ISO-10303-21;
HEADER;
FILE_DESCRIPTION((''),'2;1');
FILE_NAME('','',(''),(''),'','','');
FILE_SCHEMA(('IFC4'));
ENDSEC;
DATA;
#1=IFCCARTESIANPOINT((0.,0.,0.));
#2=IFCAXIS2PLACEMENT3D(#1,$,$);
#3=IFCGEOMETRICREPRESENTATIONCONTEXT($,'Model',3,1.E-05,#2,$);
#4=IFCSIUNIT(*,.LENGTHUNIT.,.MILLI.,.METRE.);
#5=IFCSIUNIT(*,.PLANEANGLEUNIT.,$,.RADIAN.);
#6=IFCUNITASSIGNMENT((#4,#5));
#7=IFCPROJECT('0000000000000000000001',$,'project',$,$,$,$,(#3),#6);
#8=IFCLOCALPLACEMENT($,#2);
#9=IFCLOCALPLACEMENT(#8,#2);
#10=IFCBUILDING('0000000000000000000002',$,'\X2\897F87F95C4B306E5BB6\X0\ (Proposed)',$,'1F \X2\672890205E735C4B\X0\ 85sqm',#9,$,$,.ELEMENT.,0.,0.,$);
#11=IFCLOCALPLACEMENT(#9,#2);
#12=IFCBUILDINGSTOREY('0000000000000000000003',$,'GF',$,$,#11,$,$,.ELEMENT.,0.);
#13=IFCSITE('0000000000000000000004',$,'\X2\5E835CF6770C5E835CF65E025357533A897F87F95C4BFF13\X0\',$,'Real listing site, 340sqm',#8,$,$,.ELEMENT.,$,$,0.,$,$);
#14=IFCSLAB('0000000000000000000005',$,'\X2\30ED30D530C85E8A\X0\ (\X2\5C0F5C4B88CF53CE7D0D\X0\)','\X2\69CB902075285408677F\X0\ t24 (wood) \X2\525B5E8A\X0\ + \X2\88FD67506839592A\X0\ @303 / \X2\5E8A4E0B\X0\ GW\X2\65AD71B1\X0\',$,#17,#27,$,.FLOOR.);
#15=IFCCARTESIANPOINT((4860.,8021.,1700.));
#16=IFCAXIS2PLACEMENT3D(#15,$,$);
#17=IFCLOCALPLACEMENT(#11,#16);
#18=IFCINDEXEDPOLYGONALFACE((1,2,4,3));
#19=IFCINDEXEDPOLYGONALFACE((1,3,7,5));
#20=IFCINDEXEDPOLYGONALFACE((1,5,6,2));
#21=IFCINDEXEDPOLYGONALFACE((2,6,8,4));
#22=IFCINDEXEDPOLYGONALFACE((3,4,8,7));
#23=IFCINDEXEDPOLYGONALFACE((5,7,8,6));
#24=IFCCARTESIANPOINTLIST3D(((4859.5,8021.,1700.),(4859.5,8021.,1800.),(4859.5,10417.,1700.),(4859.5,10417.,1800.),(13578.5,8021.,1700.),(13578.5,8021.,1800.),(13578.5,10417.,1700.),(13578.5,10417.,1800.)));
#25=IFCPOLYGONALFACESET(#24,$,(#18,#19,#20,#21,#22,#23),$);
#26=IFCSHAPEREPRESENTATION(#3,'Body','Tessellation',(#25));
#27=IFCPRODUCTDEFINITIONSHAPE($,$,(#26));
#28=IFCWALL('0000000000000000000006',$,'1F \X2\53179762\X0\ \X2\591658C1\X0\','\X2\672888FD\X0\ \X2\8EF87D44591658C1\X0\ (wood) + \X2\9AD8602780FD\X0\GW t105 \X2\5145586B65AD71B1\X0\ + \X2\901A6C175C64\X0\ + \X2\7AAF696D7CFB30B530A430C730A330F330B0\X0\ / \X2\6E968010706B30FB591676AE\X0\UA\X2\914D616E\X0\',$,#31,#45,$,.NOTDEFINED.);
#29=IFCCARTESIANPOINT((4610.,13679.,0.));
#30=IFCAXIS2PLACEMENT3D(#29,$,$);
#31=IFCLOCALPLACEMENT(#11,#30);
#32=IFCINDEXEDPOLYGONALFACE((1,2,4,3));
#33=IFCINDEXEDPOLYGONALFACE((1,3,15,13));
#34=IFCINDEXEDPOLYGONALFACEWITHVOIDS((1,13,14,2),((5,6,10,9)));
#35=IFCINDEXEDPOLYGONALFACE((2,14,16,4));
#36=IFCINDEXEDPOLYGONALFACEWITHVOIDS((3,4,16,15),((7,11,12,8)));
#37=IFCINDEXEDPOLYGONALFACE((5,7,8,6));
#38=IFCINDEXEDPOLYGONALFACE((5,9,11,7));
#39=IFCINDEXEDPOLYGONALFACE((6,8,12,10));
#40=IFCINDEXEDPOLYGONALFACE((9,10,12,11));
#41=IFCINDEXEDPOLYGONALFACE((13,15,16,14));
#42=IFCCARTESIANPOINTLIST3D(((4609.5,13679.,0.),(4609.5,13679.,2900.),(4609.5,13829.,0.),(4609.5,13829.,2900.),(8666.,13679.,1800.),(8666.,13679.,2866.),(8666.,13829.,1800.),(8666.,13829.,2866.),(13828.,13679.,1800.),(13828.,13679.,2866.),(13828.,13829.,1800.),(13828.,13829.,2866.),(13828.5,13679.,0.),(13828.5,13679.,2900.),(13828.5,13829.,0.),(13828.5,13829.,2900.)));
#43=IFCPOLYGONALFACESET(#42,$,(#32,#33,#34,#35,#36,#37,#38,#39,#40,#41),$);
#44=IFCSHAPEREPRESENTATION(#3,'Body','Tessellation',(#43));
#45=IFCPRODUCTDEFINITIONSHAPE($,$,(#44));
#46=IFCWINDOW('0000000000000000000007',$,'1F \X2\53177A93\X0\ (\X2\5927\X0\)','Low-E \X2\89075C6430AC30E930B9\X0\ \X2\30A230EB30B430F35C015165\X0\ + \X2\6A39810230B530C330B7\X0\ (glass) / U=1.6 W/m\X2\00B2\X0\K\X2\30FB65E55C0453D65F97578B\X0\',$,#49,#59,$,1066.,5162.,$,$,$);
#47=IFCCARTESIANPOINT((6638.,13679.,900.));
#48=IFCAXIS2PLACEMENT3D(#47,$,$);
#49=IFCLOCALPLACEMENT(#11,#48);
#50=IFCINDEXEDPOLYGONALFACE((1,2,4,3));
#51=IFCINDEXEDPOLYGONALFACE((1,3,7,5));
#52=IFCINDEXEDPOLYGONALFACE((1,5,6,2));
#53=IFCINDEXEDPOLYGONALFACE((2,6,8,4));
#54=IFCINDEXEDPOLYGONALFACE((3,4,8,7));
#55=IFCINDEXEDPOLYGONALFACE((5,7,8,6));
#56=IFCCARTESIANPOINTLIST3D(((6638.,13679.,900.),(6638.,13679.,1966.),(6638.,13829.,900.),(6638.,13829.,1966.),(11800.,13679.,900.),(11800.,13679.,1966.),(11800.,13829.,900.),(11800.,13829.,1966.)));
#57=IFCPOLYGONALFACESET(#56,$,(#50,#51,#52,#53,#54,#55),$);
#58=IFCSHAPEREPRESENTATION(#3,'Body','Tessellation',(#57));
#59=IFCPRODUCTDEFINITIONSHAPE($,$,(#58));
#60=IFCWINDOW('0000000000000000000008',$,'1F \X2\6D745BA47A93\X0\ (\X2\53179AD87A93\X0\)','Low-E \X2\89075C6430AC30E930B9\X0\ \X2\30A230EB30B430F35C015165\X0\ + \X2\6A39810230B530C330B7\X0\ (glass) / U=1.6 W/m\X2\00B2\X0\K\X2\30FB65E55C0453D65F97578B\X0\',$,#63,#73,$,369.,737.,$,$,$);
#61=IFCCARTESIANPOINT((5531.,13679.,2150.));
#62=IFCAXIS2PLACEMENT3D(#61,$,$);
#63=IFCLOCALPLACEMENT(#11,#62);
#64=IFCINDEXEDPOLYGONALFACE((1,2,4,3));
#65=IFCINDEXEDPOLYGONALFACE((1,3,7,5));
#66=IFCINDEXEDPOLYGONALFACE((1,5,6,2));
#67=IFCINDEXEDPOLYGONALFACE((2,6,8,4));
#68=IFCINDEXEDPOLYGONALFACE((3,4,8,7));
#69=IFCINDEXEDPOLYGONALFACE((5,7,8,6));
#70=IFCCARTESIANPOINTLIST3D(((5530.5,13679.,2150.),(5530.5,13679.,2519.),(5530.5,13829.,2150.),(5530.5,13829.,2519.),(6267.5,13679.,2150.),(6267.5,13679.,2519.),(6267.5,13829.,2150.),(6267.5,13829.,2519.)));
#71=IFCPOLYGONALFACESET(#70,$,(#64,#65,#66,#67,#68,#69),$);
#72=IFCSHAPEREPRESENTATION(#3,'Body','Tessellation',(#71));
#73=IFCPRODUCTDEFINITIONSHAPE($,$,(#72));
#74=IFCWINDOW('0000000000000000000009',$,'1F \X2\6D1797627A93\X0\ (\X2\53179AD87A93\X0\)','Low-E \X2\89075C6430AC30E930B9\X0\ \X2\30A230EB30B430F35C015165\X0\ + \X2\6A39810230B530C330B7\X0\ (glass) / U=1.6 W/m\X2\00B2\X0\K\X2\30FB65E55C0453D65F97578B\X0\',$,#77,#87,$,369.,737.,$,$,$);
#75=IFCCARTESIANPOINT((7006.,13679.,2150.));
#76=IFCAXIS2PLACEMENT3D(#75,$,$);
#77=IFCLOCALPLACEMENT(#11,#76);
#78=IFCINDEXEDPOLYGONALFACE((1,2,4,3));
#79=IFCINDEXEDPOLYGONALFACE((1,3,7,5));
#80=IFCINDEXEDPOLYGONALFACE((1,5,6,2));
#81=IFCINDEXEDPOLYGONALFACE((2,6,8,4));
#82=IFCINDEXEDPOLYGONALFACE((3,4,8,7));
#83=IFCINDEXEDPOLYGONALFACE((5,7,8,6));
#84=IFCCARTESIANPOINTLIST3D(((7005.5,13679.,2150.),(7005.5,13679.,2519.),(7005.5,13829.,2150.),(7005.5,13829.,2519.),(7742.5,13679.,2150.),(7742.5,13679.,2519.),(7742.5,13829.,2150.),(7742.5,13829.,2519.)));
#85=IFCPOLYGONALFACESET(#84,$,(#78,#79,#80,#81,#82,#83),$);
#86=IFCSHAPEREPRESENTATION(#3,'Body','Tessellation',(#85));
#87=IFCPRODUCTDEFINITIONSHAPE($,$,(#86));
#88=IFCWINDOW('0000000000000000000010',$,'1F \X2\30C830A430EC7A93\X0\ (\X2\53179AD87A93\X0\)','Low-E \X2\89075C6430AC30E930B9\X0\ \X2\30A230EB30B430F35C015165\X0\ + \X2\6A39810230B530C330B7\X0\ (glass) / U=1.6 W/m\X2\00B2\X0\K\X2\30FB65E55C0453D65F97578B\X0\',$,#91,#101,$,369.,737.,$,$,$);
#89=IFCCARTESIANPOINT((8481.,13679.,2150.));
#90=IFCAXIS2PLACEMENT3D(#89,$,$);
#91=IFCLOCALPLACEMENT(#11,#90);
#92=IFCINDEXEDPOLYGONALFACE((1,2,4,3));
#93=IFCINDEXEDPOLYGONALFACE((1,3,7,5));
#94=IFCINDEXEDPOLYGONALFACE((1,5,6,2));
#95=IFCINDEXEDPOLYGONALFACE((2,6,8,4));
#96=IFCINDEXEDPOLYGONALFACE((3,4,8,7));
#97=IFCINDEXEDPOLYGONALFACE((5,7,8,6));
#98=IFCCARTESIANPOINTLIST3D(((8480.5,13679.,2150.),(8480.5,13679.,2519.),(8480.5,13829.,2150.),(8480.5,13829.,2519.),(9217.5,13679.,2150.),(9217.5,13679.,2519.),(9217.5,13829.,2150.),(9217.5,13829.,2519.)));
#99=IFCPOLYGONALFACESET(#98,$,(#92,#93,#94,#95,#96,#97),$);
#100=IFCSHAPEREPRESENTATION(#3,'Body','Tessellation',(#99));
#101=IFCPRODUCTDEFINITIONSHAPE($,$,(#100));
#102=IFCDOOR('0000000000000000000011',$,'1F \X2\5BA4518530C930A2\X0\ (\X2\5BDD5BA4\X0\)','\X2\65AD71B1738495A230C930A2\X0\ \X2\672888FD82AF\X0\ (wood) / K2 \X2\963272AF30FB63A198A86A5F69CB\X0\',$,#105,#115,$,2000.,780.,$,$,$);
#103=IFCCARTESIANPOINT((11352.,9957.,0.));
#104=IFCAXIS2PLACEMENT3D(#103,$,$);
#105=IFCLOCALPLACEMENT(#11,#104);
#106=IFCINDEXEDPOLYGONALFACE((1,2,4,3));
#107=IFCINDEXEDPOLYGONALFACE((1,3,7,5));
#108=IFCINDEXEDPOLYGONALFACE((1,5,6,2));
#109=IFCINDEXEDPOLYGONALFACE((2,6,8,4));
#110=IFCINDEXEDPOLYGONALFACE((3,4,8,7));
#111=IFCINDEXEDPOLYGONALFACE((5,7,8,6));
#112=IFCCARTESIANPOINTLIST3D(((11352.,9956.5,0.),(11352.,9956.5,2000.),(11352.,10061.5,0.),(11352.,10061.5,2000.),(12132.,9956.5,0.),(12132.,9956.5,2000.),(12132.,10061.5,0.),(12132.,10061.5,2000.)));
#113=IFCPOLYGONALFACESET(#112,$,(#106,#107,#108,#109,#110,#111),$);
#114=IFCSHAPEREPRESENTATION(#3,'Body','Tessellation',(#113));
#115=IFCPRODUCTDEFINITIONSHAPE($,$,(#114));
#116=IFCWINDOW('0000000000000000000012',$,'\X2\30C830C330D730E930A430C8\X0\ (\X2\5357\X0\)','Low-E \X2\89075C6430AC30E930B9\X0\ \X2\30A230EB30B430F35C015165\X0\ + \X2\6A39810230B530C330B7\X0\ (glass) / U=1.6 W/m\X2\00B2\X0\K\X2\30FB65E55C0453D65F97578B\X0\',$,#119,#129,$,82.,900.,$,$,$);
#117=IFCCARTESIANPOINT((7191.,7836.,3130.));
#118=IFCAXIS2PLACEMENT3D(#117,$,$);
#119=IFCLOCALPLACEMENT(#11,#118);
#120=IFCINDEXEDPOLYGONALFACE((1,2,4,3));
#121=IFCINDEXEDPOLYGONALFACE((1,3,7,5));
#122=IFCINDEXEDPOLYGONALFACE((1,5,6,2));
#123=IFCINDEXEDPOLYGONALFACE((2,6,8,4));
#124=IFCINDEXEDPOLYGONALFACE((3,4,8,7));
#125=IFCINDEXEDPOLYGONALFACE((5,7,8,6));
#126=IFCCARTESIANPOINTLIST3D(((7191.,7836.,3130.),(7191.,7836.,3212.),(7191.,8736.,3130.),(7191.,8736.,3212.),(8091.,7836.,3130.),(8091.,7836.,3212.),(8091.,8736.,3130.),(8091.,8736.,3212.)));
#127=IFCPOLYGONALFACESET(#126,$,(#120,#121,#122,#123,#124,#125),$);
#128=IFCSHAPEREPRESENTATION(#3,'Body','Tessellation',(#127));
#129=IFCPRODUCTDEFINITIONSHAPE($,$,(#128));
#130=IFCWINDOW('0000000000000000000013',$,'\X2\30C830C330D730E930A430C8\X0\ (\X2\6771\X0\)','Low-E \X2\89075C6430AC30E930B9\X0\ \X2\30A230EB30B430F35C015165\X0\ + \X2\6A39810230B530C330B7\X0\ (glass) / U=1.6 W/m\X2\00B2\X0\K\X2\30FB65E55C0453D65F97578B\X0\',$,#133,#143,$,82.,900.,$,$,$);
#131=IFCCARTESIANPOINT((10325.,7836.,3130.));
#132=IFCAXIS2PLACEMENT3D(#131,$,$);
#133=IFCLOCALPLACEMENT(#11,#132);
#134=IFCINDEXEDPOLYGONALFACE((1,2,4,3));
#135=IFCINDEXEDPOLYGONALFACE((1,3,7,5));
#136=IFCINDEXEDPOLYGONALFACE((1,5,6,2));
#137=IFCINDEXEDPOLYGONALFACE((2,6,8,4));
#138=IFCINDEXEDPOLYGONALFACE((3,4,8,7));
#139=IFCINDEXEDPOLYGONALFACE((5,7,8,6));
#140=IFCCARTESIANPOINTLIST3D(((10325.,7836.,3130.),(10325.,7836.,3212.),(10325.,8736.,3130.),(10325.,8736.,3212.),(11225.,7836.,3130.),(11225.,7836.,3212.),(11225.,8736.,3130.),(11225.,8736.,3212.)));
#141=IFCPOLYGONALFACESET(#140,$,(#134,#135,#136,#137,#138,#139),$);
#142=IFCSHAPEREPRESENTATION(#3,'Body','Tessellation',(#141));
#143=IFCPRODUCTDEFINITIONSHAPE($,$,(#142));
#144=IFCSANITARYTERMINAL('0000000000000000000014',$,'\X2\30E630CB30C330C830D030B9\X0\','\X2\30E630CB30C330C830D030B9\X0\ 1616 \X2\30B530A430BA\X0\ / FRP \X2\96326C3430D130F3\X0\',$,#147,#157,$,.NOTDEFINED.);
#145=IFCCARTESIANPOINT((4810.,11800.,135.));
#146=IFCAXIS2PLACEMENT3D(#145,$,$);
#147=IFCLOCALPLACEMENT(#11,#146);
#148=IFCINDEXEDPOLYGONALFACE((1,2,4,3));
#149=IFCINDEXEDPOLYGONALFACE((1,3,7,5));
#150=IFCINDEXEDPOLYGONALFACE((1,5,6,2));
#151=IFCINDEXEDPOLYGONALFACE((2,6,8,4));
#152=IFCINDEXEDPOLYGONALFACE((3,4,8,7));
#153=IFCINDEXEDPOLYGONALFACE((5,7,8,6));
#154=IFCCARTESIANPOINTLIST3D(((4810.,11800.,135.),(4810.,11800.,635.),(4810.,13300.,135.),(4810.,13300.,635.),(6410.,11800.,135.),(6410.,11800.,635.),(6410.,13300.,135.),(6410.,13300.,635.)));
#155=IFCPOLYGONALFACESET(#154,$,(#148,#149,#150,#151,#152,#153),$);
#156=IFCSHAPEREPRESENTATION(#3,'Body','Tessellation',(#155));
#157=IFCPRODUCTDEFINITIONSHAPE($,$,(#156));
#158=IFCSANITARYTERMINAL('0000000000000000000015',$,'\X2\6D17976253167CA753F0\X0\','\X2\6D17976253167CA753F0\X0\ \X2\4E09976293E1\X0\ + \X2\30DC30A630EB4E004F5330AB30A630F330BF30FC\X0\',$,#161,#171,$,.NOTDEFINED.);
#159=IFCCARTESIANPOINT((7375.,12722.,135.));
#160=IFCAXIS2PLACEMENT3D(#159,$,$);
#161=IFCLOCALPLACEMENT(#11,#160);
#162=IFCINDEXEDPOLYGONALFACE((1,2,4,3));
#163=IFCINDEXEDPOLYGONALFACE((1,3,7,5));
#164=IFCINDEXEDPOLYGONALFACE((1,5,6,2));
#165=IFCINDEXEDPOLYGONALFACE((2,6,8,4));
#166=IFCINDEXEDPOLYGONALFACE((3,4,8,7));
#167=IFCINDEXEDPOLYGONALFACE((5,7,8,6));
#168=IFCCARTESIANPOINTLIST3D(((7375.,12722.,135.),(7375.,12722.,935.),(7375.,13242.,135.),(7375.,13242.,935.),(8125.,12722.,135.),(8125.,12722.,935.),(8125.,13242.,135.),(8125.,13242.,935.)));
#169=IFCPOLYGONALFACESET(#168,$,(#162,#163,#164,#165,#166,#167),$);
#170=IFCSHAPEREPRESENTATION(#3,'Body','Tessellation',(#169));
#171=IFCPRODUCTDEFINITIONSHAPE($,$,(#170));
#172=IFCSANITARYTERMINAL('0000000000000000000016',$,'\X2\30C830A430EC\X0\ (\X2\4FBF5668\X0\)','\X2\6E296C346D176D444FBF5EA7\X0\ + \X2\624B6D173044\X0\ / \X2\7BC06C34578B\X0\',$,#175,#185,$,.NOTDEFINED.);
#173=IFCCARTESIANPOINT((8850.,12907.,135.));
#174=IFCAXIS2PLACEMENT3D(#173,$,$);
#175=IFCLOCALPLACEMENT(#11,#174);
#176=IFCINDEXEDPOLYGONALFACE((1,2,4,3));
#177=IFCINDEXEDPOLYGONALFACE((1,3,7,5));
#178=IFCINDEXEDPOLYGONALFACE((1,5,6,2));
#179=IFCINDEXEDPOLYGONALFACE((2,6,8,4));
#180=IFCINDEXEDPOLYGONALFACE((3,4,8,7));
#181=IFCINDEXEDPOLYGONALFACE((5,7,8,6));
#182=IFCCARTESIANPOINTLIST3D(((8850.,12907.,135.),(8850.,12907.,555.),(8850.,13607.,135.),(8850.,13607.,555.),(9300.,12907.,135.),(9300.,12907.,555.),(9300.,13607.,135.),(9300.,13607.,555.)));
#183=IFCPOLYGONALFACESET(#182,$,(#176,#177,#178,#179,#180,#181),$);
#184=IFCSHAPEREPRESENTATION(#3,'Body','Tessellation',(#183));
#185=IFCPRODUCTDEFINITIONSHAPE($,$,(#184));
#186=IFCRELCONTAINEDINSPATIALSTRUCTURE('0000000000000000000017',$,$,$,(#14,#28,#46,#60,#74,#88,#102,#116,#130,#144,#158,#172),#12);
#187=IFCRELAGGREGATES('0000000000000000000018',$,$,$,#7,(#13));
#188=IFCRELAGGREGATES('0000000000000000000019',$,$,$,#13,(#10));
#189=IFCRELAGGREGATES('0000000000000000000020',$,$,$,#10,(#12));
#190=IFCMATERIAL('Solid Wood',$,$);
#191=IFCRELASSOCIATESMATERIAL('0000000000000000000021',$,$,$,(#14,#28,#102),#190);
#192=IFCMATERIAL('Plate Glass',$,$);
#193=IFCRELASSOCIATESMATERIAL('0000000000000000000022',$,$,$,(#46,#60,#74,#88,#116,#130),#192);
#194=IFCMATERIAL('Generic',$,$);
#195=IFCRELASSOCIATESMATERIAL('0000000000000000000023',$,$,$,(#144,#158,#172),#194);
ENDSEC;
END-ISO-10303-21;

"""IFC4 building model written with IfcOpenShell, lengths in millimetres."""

from ifc_helpers import new_model, si_unit, frame, frame_2d, origin, place, context, project, spatial, rectangle, extrude, material, element, fill, save


model = new_model("IFC4")

# Units and contexts
model_context = context("Model", 3, precision=1e-05, world=origin())
ifc_project = project(units=[si_unit("LENGTHUNIT", "METRE", prefix="MILLI"), si_unit("PLANEANGLEUNIT", "RADIAN")], contexts=[model_context])

# Site, building, storey
site_placement = place(None, origin())
site = spatial("IfcSite", under=ifc_project, at=site_placement, Name="広島県広島市南区西蟹屋３", ObjectType="Real listing site, 340sqm", CompositionType="ELEMENT", RefElevation=0.0)
building_placement = place(site_placement, origin())
building = spatial("IfcBuilding", under=site, at=building_placement, Name="西蟹屋の家 (Proposed)", ObjectType="1F 木造平屋 85sqm", CompositionType="ELEMENT", ElevationOfRefHeight=0.0, ElevationOfTerrain=0.0)
storey_placement = place(building_placement, origin())
storey = spatial("IfcBuildingStorey", under=building, at=storey_placement, Name="GF", CompositionType="ELEMENT", Elevation=0.0)

# Slab
ifc_material_1 = material(Name="Solid Wood")
slab_placement = place(storey_placement, frame((4860.0, 8021.0, 1700.0)))
element("IfcSlab", 1, at=slab_placement, inside=storey, material=ifc_material_1, Name="ロフト床 (小屋裏収納)", Description="構造用合板 t24 (wood) 剛床 + 製材根太 @303 / 床下 GW断熱", PredefinedType="FLOOR", context=model_context, shape_type="SweptSolid", body=[
    extrude(rectangle(XDim=8719.0, YDim=2396.0, at=frame_2d((4359.0, 1198.0))), frame((4860.0, 8021.0, 1700.0)), (0.0, 0.0, 1.0), 100.0),
])

# Wall, openings, windows
wall_1_placement = place(storey_placement, frame((4610.0, 13679.0, 0.0)))
wall_1 = element("IfcWall", 2, at=wall_1_placement, inside=storey, material=ifc_material_1, Name="1F 北面 外壁", Description="木製 軸組外壁 (wood) + 高性能GW t105 充填断熱 + 通気層 + 窯業系サイディング / 準耐火・外皮UA配慮", PredefinedType="NOTDEFINED", context=model_context, shape_type="SweptSolid", body=[
    extrude(rectangle(XDim=9219.0, YDim=150.0, at=frame_2d((4609.0, 75.0))), frame((4610.0, 13679.0, 0.0)), (0.0, 0.0, 1.0), 2900.0),
])
opening_1_placement = place(storey_placement, frame((6638.0, 13679.0, 900.0)))
opening_1 = element("IfcOpeningElement", 3, at=opening_1_placement, cuts=wall_1, PredefinedType="NOTDEFINED", context=model_context, shape_type="SweptSolid", body=[
    extrude(rectangle(XDim=5162.0, YDim=150.0, at=frame_2d((2581.0, 75.0))), frame((6638.0, 13679.0, 900.0)), (0.0, 0.0, 1.0), 1066.0),
])
opening_2_placement = place(storey_placement, frame((5531.0, 13679.0, 2150.0)))
opening_2 = element("IfcOpeningElement", 4, at=opening_2_placement, cuts=wall_1, PredefinedType="NOTDEFINED", context=model_context, shape_type="SweptSolid", body=[
    extrude(rectangle(XDim=737.0, YDim=150.0, at=frame_2d((368.0, 75.0))), frame((5531.0, 13679.0, 2150.0)), (0.0, 0.0, 1.0), 369.0),
])
opening_3_placement = place(storey_placement, frame((7006.0, 13679.0, 2150.0)))
opening_3 = element("IfcOpeningElement", 5, at=opening_3_placement, cuts=wall_1, PredefinedType="NOTDEFINED", context=model_context, shape_type="SweptSolid", body=[
    extrude(rectangle(XDim=737.0, YDim=150.0, at=frame_2d((368.0, 75.0))), frame((7006.0, 13679.0, 2150.0)), (0.0, 0.0, 1.0), 369.0),
])
opening_4_placement = place(storey_placement, frame((8481.0, 13679.0, 2150.0)))
opening_4 = element("IfcOpeningElement", 6, at=opening_4_placement, cuts=wall_1, PredefinedType="NOTDEFINED", context=model_context, shape_type="SweptSolid", body=[
    extrude(rectangle(XDim=737.0, YDim=150.0, at=frame_2d((368.0, 75.0))), frame((8481.0, 13679.0, 2150.0)), (0.0, 0.0, 1.0), 369.0),
])
ifc_material_2 = material(Name="Plate Glass")
window_1_placement = place(storey_placement, frame((6638.0, 13679.0, 900.0)))
window_1 = element("IfcWindow", 7, at=window_1_placement, inside=storey, material=ifc_material_2, Name="1F 北窓 (大)", Description="Low-E 複層ガラス アルゴン封入 + 樹脂サッシ (glass) / U=1.6 W/m²K・日射取得型", OverallHeight=1066.0, OverallWidth=5162.0, context=model_context, shape_type="SweptSolid", body=[
    extrude(rectangle(XDim=5162.0, YDim=150.0, at=frame_2d((2581.0, 75.0))), frame((6638.0, 13679.0, 900.0)), (0.0, 0.0, 1.0), 1066.0),
])
fill(opening_1, window_1)
window_2_placement = place(storey_placement, frame((5531.0, 13679.0, 2150.0)))
window_2 = element("IfcWindow", 8, at=window_2_placement, inside=storey, material=ifc_material_2, Name="1F 浴室窓 (北高窓)", Description="Low-E 複層ガラス アルゴン封入 + 樹脂サッシ (glass) / U=1.6 W/m²K・日射取得型", OverallHeight=369.0, OverallWidth=737.0, context=model_context, shape_type="SweptSolid", body=[
    extrude(rectangle(XDim=737.0, YDim=150.0, at=frame_2d((368.0, 75.0))), frame((5531.0, 13679.0, 2150.0)), (0.0, 0.0, 1.0), 369.0),
])
fill(opening_2, window_2)
window_3_placement = place(storey_placement, frame((7006.0, 13679.0, 2150.0)))
window_3 = element("IfcWindow", 9, at=window_3_placement, inside=storey, material=ifc_material_2, Name="1F 洗面窓 (北高窓)", Description="Low-E 複層ガラス アルゴン封入 + 樹脂サッシ (glass) / U=1.6 W/m²K・日射取得型", OverallHeight=369.0, OverallWidth=737.0, context=model_context, shape_type="SweptSolid", body=[
    extrude(rectangle(XDim=737.0, YDim=150.0, at=frame_2d((368.0, 75.0))), frame((7006.0, 13679.0, 2150.0)), (0.0, 0.0, 1.0), 369.0),
])
fill(opening_3, window_3)
window_4_placement = place(storey_placement, frame((8481.0, 13679.0, 2150.0)))
window_4 = element("IfcWindow", 10, at=window_4_placement, inside=storey, material=ifc_material_2, Name="1F トイレ窓 (北高窓)", Description="Low-E 複層ガラス アルゴン封入 + 樹脂サッシ (glass) / U=1.6 W/m²K・日射取得型", OverallHeight=369.0, OverallWidth=737.0, context=model_context, shape_type="SweptSolid", body=[
    extrude(rectangle(XDim=737.0, YDim=150.0, at=frame_2d((368.0, 75.0))), frame((8481.0, 13679.0, 2150.0)), (0.0, 0.0, 1.0), 369.0),
])
fill(opening_4, window_4)

# Door
door_1_placement = place(storey_placement, frame((11352.0, 9957.0, 0.0)))
element("IfcDoor", 11, at=door_1_placement, inside=storey, material=ifc_material_1, Name="1F 室内ドア (寝室)", Description="断熱玄関ドア 木製芯 (wood) / K2 防犯・採風機構", OverallHeight=2000.0, OverallWidth=780.0, context=model_context, shape_type="SweptSolid", body=[
    extrude(rectangle(XDim=780.0, YDim=105.0, at=frame_2d((390.0, 52.0))), frame((11352.0, 9957.0, 0.0)), (0.0, 0.0, 1.0), 2000.0),
])

# Windows
window_5_placement = place(storey_placement, frame((7191.0, 7836.0, 3130.0)))
element("IfcWindow", 12, at=window_5_placement, inside=storey, material=ifc_material_2, Name="トップライト (南)", Description="Low-E 複層ガラス アルゴン封入 + 樹脂サッシ (glass) / U=1.6 W/m²K・日射取得型", OverallHeight=82.0, OverallWidth=900.0, context=model_context, shape_type="SweptSolid", body=[
    extrude(rectangle(XDim=900.0, YDim=900.0, at=frame_2d((450.0, 450.0))), frame((7191.0, 7836.0, 3130.0)), (0.0, 0.0, 1.0), 82.0),
])
window_6_placement = place(storey_placement, frame((10325.0, 7836.0, 3130.0)))
element("IfcWindow", 13, at=window_6_placement, inside=storey, material=ifc_material_2, Name="トップライト (東)", Description="Low-E 複層ガラス アルゴン封入 + 樹脂サッシ (glass) / U=1.6 W/m²K・日射取得型", OverallHeight=82.0, OverallWidth=900.0, context=model_context, shape_type="SweptSolid", body=[
    extrude(rectangle(XDim=900.0, YDim=900.0, at=frame_2d((450.0, 450.0))), frame((10325.0, 7836.0, 3130.0)), (0.0, 0.0, 1.0), 82.0),
])

# Sanitary terminals
ifc_material_3 = material(Name="Generic")
sanitary_terminal_1_placement = place(storey_placement, frame((4810.0, 11800.0, 135.0)))
element("IfcSanitaryTerminal", 14, at=sanitary_terminal_1_placement, inside=storey, material=ifc_material_3, Name="ユニットバス", Description="ユニットバス 1616 サイズ / FRP 防水パン", PredefinedType="NOTDEFINED", context=model_context, shape_type="SweptSolid", body=[
    extrude(rectangle(XDim=1600.0, YDim=1500.0, at=frame_2d((800.0, 750.0))), frame((4810.0, 11800.0, 135.0)), (0.0, 0.0, 1.0), 500.0),
])
sanitary_terminal_2_placement = place(storey_placement, frame((7375.0, 12722.0, 135.0)))
element("IfcSanitaryTerminal", 15, at=sanitary_terminal_2_placement, inside=storey, material=ifc_material_3, Name="洗面化粧台", Description="洗面化粧台 三面鏡 + ボウル一体カウンター", PredefinedType="NOTDEFINED", context=model_context, shape_type="SweptSolid", body=[
    extrude(rectangle(XDim=750.0, YDim=520.0, at=frame_2d((375.0, 260.0))), frame((7375.0, 12722.0, 135.0)), (0.0, 0.0, 1.0), 800.0),
])
sanitary_terminal_3_placement = place(storey_placement, frame((8850.0, 12907.0, 135.0)))
element("IfcSanitaryTerminal", 16, at=sanitary_terminal_3_placement, inside=storey, material=ifc_material_3, Name="トイレ (便器)", Description="温水洗浄便座 + 手洗い / 節水型", PredefinedType="NOTDEFINED", context=model_context, shape_type="SweptSolid", body=[
    extrude(rectangle(XDim=450.0, YDim=700.0, at=frame_2d((225.0, 350.0))), frame((8850.0, 12907.0, 135.0)), (0.0, 0.0, 1.0), 420.0),
])

save(model, "model.ifc")
